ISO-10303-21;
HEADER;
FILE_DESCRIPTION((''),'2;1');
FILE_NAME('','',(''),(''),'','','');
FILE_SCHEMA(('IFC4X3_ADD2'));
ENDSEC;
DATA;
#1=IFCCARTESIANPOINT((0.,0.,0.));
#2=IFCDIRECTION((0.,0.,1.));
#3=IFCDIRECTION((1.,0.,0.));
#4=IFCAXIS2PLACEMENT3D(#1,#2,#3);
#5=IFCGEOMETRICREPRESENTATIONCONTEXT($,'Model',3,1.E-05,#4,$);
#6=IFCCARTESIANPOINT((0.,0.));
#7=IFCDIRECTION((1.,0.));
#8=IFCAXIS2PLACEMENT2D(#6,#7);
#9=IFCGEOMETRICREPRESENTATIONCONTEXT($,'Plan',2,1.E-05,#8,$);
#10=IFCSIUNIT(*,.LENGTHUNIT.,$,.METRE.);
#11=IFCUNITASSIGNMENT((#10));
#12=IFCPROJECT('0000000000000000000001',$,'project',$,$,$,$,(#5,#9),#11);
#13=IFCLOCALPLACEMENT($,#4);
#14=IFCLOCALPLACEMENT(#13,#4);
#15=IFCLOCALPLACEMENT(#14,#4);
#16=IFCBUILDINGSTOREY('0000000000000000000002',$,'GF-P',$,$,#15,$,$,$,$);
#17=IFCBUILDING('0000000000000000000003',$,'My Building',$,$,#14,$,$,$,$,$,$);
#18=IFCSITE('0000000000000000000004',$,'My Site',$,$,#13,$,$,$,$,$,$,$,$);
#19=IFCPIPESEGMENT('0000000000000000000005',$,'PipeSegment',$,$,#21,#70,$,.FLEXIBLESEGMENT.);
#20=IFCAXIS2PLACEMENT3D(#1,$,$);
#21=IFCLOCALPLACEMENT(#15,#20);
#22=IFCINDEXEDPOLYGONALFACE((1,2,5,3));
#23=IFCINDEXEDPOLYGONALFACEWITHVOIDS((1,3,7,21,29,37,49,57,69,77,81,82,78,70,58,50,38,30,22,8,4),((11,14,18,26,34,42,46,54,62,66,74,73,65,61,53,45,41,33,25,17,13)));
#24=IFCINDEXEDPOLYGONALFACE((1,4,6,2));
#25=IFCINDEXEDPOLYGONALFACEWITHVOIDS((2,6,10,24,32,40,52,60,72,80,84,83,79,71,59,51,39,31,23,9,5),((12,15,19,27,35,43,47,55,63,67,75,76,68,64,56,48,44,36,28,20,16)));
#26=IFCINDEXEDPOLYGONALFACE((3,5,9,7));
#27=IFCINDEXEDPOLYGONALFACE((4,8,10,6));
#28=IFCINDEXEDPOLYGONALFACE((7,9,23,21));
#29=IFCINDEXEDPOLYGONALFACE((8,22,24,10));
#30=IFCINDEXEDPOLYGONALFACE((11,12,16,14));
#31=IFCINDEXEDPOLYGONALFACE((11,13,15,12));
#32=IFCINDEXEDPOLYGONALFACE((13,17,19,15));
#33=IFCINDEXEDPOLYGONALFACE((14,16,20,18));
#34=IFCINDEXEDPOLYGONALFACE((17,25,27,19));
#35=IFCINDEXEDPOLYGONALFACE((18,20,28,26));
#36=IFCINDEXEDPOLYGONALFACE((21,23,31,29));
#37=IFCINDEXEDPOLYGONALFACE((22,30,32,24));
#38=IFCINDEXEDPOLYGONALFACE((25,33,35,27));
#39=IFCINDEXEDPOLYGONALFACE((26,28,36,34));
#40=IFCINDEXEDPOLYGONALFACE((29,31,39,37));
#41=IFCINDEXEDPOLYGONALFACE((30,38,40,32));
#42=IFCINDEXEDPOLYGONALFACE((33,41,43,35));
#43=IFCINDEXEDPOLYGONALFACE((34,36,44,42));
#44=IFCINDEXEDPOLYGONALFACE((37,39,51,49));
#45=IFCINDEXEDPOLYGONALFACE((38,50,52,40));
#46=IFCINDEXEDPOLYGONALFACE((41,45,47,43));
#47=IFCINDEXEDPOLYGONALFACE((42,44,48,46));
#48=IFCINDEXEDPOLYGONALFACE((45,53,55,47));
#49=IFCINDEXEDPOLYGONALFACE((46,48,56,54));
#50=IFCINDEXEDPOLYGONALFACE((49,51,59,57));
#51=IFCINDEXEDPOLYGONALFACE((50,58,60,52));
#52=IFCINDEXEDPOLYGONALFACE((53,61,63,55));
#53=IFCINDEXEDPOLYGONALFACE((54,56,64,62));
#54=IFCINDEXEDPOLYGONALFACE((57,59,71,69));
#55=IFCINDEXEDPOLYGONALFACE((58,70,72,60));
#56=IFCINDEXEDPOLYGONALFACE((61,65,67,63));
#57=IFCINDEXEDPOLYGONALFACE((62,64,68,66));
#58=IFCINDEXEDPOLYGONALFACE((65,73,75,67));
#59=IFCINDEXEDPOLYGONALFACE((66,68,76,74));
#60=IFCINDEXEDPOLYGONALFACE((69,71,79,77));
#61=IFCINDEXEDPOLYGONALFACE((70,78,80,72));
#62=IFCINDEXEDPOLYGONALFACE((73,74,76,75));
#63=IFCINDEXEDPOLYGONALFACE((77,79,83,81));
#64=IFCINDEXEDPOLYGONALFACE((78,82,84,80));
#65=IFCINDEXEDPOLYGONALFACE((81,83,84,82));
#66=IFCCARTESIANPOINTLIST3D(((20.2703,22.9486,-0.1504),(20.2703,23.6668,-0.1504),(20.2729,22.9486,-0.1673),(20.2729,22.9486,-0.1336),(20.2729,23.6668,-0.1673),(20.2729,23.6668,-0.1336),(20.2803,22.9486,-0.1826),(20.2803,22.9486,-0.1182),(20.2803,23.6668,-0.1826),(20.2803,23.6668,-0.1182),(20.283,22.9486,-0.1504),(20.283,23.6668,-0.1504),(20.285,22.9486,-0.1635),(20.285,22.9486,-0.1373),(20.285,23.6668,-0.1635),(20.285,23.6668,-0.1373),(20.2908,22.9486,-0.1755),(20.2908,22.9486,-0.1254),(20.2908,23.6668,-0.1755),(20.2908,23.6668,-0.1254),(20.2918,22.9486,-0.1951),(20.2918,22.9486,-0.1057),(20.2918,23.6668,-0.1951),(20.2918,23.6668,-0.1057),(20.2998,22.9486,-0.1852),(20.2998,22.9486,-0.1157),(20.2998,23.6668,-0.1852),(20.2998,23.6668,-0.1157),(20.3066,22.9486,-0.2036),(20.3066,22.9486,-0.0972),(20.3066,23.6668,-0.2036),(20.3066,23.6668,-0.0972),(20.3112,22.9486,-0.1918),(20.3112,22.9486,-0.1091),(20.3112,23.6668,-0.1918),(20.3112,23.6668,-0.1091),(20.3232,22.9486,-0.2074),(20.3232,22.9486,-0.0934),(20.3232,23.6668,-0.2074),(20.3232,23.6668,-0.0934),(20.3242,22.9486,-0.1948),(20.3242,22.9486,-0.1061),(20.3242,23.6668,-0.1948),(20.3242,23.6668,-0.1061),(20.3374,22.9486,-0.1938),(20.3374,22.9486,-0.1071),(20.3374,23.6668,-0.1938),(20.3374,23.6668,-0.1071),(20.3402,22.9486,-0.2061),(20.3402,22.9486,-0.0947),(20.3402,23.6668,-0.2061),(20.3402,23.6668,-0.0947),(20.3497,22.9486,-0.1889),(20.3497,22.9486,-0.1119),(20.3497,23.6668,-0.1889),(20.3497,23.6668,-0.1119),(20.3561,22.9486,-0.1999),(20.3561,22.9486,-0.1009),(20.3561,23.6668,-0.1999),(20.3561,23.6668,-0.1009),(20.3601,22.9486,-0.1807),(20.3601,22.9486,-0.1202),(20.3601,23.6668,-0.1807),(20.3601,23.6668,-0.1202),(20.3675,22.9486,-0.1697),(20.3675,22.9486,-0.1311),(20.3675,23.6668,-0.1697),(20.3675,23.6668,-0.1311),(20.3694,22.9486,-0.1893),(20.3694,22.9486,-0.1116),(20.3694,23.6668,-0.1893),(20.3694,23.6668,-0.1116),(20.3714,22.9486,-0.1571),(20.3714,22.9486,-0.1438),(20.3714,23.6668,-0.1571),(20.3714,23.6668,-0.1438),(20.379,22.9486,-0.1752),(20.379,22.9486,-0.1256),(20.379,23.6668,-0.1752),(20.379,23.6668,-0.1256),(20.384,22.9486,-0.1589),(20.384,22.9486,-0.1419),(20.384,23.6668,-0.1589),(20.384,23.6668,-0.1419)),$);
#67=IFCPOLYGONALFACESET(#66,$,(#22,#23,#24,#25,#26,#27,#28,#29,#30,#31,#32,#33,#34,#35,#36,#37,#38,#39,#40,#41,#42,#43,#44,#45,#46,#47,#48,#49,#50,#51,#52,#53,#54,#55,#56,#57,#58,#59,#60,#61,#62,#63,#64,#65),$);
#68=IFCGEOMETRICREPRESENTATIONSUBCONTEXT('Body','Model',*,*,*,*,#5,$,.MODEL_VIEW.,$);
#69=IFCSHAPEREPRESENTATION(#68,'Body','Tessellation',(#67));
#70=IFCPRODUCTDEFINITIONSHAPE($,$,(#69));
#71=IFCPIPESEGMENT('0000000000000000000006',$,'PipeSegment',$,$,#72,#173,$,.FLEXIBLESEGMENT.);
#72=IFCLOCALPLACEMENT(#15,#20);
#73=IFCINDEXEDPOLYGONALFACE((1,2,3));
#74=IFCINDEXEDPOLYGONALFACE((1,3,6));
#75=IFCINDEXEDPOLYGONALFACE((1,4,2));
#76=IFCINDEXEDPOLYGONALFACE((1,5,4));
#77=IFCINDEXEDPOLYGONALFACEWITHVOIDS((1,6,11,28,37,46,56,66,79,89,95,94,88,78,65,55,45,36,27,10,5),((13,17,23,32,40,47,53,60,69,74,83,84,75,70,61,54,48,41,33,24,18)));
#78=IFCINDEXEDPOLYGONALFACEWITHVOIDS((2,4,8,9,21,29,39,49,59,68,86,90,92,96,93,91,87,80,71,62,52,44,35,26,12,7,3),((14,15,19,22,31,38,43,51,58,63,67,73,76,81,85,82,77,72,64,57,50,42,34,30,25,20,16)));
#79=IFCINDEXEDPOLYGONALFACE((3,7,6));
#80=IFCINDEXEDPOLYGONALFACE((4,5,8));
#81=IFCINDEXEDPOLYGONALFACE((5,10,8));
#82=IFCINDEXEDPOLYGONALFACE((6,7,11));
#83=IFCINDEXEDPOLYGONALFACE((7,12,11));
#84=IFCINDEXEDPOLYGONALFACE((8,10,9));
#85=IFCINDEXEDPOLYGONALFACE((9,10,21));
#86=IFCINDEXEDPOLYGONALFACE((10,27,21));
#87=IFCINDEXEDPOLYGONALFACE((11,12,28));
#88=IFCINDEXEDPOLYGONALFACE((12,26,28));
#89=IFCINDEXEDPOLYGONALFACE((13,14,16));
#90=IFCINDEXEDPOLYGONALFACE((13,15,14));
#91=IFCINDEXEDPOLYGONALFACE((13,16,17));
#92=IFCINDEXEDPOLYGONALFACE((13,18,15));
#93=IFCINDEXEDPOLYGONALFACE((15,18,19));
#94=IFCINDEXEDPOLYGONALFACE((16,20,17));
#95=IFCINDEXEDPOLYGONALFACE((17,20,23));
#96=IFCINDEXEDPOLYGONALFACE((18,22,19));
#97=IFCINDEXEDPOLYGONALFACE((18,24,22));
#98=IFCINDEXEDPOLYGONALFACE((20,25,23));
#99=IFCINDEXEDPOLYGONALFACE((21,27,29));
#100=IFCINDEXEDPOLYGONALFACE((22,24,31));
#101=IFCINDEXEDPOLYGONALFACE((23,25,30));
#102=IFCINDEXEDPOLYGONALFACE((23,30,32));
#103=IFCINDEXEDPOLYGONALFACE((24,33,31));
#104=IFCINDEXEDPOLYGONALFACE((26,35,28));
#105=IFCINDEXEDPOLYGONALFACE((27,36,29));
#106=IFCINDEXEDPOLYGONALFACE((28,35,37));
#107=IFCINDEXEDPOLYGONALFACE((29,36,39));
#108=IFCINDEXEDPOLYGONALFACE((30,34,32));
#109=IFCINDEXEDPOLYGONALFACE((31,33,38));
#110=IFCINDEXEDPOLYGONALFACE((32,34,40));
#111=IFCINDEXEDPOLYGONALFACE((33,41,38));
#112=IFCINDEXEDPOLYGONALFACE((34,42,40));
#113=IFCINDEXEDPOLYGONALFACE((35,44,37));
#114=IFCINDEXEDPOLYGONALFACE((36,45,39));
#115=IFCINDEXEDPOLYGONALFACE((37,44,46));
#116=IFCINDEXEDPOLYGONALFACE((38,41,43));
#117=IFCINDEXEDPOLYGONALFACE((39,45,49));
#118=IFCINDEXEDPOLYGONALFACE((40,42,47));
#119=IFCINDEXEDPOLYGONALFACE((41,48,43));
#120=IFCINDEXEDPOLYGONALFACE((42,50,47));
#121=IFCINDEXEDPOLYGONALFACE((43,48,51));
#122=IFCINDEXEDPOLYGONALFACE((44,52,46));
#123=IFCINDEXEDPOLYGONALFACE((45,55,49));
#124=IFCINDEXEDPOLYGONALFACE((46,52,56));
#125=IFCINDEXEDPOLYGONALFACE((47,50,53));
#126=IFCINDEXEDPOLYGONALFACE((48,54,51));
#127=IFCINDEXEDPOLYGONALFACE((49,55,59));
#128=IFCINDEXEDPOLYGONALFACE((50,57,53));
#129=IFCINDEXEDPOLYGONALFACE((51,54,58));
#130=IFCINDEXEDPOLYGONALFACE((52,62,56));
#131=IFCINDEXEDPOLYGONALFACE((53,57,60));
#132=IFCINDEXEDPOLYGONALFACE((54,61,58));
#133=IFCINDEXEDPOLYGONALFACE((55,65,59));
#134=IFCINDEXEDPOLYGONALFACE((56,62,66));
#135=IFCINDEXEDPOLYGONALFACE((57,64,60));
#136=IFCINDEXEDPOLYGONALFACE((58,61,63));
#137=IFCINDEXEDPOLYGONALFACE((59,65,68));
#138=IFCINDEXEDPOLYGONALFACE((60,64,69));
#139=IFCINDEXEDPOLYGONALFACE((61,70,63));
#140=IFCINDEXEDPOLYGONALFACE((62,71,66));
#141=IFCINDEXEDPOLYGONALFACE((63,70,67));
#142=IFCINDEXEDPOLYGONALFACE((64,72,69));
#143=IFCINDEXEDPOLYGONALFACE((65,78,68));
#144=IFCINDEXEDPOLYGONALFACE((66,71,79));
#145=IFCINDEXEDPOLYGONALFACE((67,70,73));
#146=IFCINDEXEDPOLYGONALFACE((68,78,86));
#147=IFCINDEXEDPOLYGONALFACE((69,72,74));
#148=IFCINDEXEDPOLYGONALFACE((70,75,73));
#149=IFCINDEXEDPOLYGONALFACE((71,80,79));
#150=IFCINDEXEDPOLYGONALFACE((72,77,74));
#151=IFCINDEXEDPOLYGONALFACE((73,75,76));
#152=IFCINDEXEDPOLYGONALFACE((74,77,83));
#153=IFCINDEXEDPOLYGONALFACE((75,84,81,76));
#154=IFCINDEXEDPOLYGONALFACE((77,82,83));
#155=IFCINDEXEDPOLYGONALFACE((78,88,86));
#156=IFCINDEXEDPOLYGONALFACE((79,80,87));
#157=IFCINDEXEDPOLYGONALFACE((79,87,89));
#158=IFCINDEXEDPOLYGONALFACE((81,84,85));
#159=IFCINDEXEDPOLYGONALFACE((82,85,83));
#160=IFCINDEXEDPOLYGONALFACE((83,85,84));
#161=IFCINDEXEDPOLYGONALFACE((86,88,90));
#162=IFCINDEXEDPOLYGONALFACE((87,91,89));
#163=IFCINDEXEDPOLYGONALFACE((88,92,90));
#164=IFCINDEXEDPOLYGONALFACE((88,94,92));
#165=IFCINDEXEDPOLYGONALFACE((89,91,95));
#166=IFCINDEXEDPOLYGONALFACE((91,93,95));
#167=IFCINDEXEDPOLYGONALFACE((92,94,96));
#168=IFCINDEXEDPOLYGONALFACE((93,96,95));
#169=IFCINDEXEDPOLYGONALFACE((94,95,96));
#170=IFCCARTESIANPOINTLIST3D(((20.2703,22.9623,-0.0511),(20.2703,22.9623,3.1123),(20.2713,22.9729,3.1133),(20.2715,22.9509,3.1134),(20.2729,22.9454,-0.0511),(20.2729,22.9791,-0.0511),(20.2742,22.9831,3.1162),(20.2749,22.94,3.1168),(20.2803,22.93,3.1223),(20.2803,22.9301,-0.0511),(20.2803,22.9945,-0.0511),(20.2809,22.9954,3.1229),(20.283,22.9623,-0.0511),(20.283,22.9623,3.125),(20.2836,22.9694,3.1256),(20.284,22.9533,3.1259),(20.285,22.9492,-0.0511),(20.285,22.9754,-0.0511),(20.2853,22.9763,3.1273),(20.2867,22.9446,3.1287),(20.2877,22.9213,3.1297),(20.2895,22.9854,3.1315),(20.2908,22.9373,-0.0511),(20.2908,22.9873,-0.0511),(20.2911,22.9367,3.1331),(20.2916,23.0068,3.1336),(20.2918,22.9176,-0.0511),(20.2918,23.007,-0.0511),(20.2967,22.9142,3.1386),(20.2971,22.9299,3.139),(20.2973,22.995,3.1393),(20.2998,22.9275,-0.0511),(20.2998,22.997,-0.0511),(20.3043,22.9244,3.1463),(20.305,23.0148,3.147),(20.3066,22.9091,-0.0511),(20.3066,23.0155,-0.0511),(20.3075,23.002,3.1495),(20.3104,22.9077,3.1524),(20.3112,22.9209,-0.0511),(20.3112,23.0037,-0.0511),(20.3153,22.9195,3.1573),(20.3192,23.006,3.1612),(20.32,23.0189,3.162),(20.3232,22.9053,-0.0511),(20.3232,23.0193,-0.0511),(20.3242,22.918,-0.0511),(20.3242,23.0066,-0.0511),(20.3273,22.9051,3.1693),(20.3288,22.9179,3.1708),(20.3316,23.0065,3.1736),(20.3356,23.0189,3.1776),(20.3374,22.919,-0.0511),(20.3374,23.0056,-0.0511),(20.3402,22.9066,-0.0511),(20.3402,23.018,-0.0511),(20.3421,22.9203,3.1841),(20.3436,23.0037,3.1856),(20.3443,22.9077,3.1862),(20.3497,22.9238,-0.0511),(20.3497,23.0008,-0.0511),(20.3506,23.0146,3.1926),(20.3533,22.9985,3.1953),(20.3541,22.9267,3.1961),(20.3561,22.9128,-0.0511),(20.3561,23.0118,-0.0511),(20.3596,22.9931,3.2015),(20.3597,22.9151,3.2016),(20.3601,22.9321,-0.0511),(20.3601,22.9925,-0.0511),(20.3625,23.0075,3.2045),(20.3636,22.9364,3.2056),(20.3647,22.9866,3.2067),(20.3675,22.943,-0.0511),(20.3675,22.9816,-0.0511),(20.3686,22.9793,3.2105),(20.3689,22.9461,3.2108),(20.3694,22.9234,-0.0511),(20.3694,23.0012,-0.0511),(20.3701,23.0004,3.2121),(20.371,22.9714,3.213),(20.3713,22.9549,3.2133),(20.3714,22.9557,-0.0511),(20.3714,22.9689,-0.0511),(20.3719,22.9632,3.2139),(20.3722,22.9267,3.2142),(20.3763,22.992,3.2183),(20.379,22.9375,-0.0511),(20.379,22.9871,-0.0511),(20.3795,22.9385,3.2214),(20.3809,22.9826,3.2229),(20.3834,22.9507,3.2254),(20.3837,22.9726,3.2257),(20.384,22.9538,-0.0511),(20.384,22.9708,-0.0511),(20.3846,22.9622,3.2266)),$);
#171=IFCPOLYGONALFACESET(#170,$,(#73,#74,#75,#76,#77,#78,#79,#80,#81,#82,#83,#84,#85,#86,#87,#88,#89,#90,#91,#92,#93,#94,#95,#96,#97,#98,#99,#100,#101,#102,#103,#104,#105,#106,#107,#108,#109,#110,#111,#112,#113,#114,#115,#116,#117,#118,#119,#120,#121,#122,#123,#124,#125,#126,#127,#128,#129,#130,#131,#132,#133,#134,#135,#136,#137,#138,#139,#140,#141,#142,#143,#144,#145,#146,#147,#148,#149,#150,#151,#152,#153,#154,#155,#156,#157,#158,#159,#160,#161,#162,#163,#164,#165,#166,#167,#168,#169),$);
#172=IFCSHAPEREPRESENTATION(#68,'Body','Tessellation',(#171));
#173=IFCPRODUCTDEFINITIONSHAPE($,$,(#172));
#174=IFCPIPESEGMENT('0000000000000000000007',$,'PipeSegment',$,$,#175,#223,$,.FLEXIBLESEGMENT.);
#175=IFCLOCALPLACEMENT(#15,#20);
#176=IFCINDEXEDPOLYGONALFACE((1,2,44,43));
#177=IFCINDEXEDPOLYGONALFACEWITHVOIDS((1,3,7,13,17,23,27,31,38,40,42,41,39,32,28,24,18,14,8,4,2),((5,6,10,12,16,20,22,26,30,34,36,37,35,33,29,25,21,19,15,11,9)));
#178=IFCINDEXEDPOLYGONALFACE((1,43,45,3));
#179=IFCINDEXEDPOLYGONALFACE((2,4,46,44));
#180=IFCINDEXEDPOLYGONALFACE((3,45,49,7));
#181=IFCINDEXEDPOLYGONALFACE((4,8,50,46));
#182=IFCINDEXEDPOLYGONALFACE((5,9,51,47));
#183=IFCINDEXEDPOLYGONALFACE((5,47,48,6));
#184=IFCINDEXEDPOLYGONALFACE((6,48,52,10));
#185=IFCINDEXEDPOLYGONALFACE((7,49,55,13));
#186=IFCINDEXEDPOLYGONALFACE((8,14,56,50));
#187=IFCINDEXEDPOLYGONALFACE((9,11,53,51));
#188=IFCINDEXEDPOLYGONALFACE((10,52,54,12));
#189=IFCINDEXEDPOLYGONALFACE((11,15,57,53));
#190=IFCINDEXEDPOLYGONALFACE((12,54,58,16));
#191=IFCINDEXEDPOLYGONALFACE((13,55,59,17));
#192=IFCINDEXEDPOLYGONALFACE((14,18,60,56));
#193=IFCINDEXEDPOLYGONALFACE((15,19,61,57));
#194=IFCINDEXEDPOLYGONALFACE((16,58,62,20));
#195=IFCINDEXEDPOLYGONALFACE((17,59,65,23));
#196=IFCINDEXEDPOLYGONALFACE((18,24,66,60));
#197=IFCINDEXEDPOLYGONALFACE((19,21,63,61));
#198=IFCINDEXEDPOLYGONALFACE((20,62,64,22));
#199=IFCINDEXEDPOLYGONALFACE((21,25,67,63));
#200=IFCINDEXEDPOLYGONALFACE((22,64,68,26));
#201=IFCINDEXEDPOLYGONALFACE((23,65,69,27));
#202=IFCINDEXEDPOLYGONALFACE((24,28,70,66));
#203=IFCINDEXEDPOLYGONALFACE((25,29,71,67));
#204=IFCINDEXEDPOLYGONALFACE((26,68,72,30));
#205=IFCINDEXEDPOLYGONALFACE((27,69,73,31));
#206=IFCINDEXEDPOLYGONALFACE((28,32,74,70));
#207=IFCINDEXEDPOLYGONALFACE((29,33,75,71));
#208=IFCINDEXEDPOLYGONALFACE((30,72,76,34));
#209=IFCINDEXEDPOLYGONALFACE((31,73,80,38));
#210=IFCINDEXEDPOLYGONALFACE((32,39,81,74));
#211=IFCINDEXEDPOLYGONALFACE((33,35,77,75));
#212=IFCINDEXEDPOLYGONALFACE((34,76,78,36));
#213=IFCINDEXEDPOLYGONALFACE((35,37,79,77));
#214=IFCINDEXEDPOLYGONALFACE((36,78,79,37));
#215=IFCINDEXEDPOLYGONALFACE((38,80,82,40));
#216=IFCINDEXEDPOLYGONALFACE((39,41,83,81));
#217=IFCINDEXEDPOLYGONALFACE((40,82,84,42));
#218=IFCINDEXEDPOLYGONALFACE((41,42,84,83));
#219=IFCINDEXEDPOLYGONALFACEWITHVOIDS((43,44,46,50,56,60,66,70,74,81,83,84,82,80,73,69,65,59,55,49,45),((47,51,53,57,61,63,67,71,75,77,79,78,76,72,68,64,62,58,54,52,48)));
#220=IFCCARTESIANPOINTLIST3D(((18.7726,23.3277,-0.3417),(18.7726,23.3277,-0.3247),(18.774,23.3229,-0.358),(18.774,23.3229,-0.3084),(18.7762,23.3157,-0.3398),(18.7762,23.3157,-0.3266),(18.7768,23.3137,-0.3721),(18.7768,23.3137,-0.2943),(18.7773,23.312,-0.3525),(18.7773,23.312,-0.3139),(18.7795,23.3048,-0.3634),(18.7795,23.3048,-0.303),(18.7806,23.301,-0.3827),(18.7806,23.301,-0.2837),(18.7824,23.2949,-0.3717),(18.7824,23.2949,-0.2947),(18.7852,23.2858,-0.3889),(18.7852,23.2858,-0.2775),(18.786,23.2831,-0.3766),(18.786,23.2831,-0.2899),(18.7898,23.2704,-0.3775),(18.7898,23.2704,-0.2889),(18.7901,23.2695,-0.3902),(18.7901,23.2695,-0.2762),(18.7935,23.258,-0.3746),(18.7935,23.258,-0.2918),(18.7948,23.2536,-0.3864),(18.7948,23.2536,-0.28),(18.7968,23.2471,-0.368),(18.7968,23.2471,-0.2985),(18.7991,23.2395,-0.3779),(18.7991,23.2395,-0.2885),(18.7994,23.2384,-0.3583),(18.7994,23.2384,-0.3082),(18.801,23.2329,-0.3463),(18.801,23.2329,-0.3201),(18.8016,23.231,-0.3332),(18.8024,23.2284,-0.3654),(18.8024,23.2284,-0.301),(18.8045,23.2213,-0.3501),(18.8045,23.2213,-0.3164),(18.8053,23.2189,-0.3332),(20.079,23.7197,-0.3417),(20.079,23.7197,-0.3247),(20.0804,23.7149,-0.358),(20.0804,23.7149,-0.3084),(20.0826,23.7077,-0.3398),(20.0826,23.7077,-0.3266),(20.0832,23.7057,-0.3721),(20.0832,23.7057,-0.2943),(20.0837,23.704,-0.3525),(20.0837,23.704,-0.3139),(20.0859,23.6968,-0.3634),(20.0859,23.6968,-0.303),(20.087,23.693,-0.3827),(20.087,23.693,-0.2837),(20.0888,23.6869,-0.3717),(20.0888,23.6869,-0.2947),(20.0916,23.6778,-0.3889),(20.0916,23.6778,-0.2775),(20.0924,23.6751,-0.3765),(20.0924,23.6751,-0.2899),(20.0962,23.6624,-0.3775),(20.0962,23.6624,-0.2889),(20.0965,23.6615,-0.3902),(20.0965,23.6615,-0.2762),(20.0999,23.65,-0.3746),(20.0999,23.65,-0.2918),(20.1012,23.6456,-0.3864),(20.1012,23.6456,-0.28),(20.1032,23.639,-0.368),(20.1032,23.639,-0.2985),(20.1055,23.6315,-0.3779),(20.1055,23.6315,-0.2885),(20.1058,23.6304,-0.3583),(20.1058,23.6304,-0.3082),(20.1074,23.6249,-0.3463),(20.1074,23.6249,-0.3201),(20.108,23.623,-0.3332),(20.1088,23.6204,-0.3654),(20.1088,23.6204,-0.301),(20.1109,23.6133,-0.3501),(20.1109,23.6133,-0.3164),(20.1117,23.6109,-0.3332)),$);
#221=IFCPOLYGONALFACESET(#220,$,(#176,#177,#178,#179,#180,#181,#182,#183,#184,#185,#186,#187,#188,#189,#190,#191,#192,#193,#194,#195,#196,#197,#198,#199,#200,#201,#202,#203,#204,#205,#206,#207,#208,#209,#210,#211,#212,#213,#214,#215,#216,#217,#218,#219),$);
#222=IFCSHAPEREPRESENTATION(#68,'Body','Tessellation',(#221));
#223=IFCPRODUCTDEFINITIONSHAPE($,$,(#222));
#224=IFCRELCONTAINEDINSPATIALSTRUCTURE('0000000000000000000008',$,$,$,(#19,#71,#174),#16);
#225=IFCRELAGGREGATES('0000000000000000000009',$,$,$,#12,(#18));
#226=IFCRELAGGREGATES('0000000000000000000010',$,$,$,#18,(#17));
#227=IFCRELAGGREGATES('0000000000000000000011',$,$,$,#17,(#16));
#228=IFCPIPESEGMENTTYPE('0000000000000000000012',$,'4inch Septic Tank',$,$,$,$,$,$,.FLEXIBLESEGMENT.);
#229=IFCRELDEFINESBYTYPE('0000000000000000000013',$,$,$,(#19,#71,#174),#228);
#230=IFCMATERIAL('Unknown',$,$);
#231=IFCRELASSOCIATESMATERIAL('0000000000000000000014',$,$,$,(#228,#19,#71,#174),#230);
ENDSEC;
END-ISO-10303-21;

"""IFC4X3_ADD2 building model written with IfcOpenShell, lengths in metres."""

from ifc_helpers import new_model, si_unit, frame, origin_with_axes, origin_2d_with_axis, place, context, subcontext, project, spatial, hollow_circle, extrude, clip, halfspace, material, material_profile, profile_set, profile_usage, type_object, element, save


model = new_model("IFC4X3_ADD2")

# Units and contexts
model_context = context("Model", 3, precision=1e-05, world=origin_with_axes())
plan_context = context("Plan", 2, precision=1e-05, world=origin_2d_with_axis())
body_context = subcontext(model_context, "Body", "Model", "MODEL_VIEW")
ifc_project = project(units=[si_unit("LENGTHUNIT", "METRE")], contexts=[model_context, plan_context])

# Site, building, storey
site_placement = place(None, origin_with_axes())
site = spatial("IfcSite", under=ifc_project, at=site_placement, Name="My Site")
building_placement = place(site_placement, origin_with_axes())
building = spatial("IfcBuilding", under=site, at=building_placement, Name="My Building")
storey_placement = place(building_placement, origin_with_axes())
storey = spatial("IfcBuildingStorey", under=building, at=storey_placement, Name="GF-P")

# Pipe segments
ifc_material_1 = material(Name="Unknown")
ifc_material_profile_1 = material_profile(ifc_material_1, hollow_circle(Radius=0.0571, WallThickness=0.0127))
ifc_profile_set_1 = profile_set([ifc_material_profile_1], Name="blackwater")
pipe_segment_type_1 = type_object("IfcPipeSegmentType", Name="4inch Septic Tank", PredefinedType="FLEXIBLESEGMENT", material=ifc_profile_set_1)
ifc_profile_usage_1 = profile_usage(ifc_profile_set_1, cardinal=5)
pipe_segment_1_placement = place(storey_placement, frame((20.3275, 22.9486, -0.1504), z_axis=(0.0, 1.0, 0.0), x_axis=(-1.0, 0.0, 0.0)))
element("IfcPipeSegment", 1, at=pipe_segment_1_placement, inside=storey, type_object=pipe_segment_type_1, material=ifc_profile_usage_1, Name="PipeSegment", PredefinedType="FLEXIBLESEGMENT", context=body_context, shape_type="SweptSolid", body=[
    extrude(hollow_circle(Radius=0.0571, WallThickness=0.0127), origin_with_axes(), (0.0, 0.0, 1.0), 0.7182),
])
ifc_profile_usage_2 = profile_usage(ifc_profile_set_1, cardinal=5)
pipe_segment_2_placement = place(storey_placement, frame((20.3275, 22.9623, -0.0511), z_axis=(0.0, 0.0, 1.0), x_axis=(-1.0, 0.0, 0.0)))
element("IfcPipeSegment", 2, at=pipe_segment_2_placement, inside=storey, type_object=pipe_segment_type_1, material=ifc_profile_usage_2, Name="PipeSegment", PredefinedType="FLEXIBLESEGMENT", context=body_context, shape_type="Clipping", body=[
    clip(extrude(hollow_circle(Radius=0.0571, WallThickness=0.0127), origin_with_axes(), (0.0, 0.0, 1.0), 3.3349), halfspace(frame((0.0976, 0.0, 3.123), z_axis=(0.707107, 0.0, 0.707107), x_axis=(0.0, -1.0, 0.0)), False)),
])
ifc_profile_usage_3 = profile_usage(ifc_profile_set_1, cardinal=5)
pipe_segment_3_placement = place(storey_placement, frame((20.0952, 23.6656, -0.3332), z_axis=(-0.957811, -0.287399, 0.0), x_axis=(0.287399, -0.957811, 0.0)))
element("IfcPipeSegment", 3, at=pipe_segment_3_placement, inside=storey, type_object=pipe_segment_type_1, material=ifc_profile_usage_3, Name="PipeSegment", PredefinedType="FLEXIBLESEGMENT", context=body_context, shape_type="SweptSolid", body=[
    extrude(hollow_circle(Radius=0.0571, WallThickness=0.0127), origin_with_axes(), (0.0, 0.0, 1.0), 1.3639),
])

save(model, "model.ifc")
